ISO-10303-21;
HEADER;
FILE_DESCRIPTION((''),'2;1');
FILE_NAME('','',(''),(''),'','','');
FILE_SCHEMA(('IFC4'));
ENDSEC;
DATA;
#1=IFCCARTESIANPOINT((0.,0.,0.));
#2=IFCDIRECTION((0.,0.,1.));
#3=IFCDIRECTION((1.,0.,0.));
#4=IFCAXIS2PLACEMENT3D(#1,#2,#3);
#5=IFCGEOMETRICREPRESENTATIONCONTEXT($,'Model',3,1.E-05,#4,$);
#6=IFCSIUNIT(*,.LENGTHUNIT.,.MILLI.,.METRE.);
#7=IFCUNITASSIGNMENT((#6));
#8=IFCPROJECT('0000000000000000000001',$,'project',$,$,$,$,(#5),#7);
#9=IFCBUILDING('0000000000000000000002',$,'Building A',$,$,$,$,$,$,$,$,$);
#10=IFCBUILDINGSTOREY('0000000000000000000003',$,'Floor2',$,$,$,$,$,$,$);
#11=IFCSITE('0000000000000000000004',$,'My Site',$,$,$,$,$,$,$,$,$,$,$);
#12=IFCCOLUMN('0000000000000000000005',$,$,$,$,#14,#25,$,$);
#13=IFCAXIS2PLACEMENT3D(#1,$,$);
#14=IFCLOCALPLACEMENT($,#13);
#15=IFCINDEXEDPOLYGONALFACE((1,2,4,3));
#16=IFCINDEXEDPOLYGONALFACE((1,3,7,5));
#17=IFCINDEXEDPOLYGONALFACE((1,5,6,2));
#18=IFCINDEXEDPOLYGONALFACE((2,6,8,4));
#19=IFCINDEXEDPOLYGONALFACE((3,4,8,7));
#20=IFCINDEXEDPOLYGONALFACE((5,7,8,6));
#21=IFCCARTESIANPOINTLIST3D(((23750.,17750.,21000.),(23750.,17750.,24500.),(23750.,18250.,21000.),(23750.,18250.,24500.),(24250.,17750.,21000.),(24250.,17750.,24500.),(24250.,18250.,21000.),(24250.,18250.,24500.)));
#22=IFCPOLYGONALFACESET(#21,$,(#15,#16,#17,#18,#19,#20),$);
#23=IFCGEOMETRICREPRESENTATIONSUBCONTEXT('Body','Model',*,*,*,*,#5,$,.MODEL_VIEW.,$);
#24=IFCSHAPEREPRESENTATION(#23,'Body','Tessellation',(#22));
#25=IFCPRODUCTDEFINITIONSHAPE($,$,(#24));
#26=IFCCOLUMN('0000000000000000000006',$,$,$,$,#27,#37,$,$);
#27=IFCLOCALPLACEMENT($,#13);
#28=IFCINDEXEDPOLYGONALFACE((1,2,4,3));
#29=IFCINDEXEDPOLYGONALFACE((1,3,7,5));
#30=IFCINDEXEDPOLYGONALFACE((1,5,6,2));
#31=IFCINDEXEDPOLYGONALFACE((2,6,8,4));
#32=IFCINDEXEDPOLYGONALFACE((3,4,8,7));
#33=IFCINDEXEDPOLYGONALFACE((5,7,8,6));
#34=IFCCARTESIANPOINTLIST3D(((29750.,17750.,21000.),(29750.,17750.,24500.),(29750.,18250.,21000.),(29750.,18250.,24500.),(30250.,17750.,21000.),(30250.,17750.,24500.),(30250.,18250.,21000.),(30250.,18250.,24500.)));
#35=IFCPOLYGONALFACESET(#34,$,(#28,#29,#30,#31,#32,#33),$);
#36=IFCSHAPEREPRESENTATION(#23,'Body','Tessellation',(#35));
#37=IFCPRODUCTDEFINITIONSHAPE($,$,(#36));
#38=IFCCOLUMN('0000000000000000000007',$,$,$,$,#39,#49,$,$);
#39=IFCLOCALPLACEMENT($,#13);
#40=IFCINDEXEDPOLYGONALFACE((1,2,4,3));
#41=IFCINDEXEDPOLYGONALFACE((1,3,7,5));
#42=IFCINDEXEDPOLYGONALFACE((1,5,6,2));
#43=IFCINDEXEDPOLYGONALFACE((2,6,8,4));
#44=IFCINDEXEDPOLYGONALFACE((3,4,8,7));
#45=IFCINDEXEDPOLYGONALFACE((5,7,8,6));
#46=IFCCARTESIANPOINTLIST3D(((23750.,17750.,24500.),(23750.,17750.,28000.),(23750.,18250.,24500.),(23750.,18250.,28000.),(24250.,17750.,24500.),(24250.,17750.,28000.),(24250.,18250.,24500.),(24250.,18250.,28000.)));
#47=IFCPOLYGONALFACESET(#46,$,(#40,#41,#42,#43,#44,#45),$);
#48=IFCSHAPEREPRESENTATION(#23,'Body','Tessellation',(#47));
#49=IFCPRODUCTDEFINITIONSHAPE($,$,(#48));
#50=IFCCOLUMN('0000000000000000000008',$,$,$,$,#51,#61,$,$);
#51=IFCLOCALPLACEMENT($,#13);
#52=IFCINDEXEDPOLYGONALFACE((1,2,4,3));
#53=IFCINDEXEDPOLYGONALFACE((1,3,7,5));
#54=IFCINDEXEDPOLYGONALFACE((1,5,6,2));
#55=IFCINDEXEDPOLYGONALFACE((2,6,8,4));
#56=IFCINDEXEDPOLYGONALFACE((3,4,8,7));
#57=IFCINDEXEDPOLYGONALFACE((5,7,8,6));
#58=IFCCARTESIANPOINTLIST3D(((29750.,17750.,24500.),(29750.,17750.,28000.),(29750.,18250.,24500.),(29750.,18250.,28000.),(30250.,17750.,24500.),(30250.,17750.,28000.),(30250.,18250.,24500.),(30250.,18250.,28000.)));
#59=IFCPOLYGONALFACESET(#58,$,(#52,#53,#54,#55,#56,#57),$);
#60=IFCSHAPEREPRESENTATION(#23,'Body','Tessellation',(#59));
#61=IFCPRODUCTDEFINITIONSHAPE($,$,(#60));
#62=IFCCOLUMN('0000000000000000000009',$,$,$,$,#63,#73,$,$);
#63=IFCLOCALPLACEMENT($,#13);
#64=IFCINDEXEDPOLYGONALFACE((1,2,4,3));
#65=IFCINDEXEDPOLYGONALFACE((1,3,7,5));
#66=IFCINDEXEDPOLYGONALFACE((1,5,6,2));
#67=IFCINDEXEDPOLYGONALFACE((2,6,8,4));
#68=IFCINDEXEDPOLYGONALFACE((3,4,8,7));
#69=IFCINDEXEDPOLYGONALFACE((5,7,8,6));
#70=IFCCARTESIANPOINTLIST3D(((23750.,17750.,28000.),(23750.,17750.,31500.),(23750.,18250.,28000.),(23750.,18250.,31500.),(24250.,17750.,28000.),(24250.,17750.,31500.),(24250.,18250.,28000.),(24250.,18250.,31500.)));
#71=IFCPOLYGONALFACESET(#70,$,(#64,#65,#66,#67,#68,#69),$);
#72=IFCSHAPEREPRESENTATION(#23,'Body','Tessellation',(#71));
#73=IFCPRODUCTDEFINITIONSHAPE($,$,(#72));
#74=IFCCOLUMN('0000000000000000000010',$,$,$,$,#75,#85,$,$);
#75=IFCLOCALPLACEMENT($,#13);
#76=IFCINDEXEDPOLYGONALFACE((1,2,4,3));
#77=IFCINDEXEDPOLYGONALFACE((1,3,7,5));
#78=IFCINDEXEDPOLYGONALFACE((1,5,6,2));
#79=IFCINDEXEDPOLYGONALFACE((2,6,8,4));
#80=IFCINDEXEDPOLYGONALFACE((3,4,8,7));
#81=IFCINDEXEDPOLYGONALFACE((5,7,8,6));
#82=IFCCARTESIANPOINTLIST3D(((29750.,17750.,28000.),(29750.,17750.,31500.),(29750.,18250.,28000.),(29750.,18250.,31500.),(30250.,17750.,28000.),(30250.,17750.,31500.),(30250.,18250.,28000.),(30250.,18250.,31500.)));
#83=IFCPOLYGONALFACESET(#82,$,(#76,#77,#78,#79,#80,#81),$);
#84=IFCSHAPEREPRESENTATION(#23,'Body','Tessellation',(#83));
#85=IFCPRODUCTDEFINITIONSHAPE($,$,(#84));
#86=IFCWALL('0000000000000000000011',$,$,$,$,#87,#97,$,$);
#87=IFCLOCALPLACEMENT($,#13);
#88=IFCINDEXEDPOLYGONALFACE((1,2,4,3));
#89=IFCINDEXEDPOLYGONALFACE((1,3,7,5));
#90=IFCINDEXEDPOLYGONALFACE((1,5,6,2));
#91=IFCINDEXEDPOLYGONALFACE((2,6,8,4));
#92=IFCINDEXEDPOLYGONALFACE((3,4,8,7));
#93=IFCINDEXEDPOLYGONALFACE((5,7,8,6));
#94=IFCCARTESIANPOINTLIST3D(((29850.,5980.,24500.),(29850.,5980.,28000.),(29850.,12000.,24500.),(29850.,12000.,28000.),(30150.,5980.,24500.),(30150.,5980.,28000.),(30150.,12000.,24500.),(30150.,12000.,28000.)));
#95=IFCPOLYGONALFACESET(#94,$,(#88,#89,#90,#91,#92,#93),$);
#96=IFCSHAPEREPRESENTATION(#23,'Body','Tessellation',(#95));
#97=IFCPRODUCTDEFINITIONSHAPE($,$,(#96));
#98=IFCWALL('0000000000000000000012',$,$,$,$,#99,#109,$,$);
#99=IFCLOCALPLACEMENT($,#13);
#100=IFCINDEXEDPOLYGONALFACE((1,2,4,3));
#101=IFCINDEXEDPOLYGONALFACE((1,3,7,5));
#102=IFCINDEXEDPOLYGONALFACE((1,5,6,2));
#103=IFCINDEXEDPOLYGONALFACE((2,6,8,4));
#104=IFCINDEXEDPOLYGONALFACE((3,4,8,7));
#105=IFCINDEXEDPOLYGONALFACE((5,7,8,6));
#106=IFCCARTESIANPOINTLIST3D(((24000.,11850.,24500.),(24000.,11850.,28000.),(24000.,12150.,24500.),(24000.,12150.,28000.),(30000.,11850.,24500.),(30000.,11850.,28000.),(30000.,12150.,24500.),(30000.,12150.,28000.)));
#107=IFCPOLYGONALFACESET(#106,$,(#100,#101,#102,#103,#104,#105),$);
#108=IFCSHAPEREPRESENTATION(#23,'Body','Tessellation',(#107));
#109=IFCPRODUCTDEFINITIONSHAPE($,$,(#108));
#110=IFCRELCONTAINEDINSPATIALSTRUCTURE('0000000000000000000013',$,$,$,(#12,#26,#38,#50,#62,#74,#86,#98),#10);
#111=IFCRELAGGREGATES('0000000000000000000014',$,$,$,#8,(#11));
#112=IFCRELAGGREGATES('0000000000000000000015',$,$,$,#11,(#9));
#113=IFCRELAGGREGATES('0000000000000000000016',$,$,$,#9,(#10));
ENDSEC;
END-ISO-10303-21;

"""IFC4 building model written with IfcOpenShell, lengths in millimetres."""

from ifc_helpers import new_model, si_unit, frame, origin_with_axes, place, context, subcontext, project, spatial, line, indexed_curve, outline, extrude, element, save


model = new_model("IFC4")

# Units and contexts
model_context = context("Model", 3, precision=1e-05, world=origin_with_axes())
body_context = subcontext(model_context, "Body", "Model", "MODEL_VIEW")
ifc_project = project(units=[si_unit("LENGTHUNIT", "METRE", prefix="MILLI")], contexts=[model_context])

# Site, building, storey
site = spatial("IfcSite", under=ifc_project, Name="My Site")
building = spatial("IfcBuilding", under=site, Name="Building A")
storey = spatial("IfcBuildingStorey", under=building, Name="Floor2")

# Columns
for number, where, z_axis, x_axis in (
    (1, (24000.0, 18000.0, 21000.0), (0.0, 0.0, 1.0), (1.0, 0.0, 0.0)),
    (2, (30000.0, 18000.0, 21000.0), (0.0, 0.0, 1.0), (1.0, 0.0, 0.0)),
    (3, (24000.0, 18000.0, 24500.0), (0.0, 0.0, 1.0), (1.0, 0.0, 0.0)),
    (4, (30000.0, 18000.0, 24500.0), (0.0, 0.0, 1.0), (1.0, 0.0, 0.0)),
    (5, (24000.0, 18000.0, 28000.0), (0.0, 0.0, 1.0), (1.0, 0.0, 0.0)),
    (6, (30000.0, 18000.0, 28000.0), (0.0, 0.0, 1.0), (1.0, 0.0, 0.0)),
):
    element("IfcColumn", number, at=place(None, frame(where, z_axis=z_axis, x_axis=x_axis)), inside=storey, context=body_context, shape_type="SweptSolid", body=[
        extrude(outline(indexed_curve([(-250.0, -250.0), (250.0, -250.0), (250.0, 250.0), (-250.0, 250.0)], segments=[line(1, 2, 3, 4, 1)])), origin_with_axes(), (0.0, 0.0, 1.0), 3500.0),
    ])

# Walls
wall_1_placement = place(None, frame((29850.0, 12000.0, 24500.0), z_axis=(0.0, 0.0, 1.0), x_axis=(0.0, -1.0, 0.0)))
element("IfcWall", 7, at=wall_1_placement, inside=storey, context=body_context, shape_type="SweptSolid", body=[
    extrude(outline(indexed_curve([(0.0, 0.0), (0.0, 300.0), (6020.0, 300.0), (6020.0, 0.0), (0.0, 0.0)], self_intersect=False)), origin_with_axes(), (0.0, 0.0, 1.0), 3500.0),
])
wall_2_placement = place(None, frame((24000.0, 11850.0, 24500.0), z_axis=(0.0, 0.0, 1.0), x_axis=(1.0, 0.0, 0.0)))
element("IfcWall", 8, at=wall_2_placement, inside=storey, context=body_context, shape_type="SweptSolid", body=[
    extrude(outline(indexed_curve([(0.0, 0.0), (0.0, 300.0), (6000.0, 300.0), (6000.0, 0.0), (0.0, 0.0)], self_intersect=False)), origin_with_axes(), (0.0, 0.0, 1.0), 3500.0),
])

save(model, "model.ifc")
